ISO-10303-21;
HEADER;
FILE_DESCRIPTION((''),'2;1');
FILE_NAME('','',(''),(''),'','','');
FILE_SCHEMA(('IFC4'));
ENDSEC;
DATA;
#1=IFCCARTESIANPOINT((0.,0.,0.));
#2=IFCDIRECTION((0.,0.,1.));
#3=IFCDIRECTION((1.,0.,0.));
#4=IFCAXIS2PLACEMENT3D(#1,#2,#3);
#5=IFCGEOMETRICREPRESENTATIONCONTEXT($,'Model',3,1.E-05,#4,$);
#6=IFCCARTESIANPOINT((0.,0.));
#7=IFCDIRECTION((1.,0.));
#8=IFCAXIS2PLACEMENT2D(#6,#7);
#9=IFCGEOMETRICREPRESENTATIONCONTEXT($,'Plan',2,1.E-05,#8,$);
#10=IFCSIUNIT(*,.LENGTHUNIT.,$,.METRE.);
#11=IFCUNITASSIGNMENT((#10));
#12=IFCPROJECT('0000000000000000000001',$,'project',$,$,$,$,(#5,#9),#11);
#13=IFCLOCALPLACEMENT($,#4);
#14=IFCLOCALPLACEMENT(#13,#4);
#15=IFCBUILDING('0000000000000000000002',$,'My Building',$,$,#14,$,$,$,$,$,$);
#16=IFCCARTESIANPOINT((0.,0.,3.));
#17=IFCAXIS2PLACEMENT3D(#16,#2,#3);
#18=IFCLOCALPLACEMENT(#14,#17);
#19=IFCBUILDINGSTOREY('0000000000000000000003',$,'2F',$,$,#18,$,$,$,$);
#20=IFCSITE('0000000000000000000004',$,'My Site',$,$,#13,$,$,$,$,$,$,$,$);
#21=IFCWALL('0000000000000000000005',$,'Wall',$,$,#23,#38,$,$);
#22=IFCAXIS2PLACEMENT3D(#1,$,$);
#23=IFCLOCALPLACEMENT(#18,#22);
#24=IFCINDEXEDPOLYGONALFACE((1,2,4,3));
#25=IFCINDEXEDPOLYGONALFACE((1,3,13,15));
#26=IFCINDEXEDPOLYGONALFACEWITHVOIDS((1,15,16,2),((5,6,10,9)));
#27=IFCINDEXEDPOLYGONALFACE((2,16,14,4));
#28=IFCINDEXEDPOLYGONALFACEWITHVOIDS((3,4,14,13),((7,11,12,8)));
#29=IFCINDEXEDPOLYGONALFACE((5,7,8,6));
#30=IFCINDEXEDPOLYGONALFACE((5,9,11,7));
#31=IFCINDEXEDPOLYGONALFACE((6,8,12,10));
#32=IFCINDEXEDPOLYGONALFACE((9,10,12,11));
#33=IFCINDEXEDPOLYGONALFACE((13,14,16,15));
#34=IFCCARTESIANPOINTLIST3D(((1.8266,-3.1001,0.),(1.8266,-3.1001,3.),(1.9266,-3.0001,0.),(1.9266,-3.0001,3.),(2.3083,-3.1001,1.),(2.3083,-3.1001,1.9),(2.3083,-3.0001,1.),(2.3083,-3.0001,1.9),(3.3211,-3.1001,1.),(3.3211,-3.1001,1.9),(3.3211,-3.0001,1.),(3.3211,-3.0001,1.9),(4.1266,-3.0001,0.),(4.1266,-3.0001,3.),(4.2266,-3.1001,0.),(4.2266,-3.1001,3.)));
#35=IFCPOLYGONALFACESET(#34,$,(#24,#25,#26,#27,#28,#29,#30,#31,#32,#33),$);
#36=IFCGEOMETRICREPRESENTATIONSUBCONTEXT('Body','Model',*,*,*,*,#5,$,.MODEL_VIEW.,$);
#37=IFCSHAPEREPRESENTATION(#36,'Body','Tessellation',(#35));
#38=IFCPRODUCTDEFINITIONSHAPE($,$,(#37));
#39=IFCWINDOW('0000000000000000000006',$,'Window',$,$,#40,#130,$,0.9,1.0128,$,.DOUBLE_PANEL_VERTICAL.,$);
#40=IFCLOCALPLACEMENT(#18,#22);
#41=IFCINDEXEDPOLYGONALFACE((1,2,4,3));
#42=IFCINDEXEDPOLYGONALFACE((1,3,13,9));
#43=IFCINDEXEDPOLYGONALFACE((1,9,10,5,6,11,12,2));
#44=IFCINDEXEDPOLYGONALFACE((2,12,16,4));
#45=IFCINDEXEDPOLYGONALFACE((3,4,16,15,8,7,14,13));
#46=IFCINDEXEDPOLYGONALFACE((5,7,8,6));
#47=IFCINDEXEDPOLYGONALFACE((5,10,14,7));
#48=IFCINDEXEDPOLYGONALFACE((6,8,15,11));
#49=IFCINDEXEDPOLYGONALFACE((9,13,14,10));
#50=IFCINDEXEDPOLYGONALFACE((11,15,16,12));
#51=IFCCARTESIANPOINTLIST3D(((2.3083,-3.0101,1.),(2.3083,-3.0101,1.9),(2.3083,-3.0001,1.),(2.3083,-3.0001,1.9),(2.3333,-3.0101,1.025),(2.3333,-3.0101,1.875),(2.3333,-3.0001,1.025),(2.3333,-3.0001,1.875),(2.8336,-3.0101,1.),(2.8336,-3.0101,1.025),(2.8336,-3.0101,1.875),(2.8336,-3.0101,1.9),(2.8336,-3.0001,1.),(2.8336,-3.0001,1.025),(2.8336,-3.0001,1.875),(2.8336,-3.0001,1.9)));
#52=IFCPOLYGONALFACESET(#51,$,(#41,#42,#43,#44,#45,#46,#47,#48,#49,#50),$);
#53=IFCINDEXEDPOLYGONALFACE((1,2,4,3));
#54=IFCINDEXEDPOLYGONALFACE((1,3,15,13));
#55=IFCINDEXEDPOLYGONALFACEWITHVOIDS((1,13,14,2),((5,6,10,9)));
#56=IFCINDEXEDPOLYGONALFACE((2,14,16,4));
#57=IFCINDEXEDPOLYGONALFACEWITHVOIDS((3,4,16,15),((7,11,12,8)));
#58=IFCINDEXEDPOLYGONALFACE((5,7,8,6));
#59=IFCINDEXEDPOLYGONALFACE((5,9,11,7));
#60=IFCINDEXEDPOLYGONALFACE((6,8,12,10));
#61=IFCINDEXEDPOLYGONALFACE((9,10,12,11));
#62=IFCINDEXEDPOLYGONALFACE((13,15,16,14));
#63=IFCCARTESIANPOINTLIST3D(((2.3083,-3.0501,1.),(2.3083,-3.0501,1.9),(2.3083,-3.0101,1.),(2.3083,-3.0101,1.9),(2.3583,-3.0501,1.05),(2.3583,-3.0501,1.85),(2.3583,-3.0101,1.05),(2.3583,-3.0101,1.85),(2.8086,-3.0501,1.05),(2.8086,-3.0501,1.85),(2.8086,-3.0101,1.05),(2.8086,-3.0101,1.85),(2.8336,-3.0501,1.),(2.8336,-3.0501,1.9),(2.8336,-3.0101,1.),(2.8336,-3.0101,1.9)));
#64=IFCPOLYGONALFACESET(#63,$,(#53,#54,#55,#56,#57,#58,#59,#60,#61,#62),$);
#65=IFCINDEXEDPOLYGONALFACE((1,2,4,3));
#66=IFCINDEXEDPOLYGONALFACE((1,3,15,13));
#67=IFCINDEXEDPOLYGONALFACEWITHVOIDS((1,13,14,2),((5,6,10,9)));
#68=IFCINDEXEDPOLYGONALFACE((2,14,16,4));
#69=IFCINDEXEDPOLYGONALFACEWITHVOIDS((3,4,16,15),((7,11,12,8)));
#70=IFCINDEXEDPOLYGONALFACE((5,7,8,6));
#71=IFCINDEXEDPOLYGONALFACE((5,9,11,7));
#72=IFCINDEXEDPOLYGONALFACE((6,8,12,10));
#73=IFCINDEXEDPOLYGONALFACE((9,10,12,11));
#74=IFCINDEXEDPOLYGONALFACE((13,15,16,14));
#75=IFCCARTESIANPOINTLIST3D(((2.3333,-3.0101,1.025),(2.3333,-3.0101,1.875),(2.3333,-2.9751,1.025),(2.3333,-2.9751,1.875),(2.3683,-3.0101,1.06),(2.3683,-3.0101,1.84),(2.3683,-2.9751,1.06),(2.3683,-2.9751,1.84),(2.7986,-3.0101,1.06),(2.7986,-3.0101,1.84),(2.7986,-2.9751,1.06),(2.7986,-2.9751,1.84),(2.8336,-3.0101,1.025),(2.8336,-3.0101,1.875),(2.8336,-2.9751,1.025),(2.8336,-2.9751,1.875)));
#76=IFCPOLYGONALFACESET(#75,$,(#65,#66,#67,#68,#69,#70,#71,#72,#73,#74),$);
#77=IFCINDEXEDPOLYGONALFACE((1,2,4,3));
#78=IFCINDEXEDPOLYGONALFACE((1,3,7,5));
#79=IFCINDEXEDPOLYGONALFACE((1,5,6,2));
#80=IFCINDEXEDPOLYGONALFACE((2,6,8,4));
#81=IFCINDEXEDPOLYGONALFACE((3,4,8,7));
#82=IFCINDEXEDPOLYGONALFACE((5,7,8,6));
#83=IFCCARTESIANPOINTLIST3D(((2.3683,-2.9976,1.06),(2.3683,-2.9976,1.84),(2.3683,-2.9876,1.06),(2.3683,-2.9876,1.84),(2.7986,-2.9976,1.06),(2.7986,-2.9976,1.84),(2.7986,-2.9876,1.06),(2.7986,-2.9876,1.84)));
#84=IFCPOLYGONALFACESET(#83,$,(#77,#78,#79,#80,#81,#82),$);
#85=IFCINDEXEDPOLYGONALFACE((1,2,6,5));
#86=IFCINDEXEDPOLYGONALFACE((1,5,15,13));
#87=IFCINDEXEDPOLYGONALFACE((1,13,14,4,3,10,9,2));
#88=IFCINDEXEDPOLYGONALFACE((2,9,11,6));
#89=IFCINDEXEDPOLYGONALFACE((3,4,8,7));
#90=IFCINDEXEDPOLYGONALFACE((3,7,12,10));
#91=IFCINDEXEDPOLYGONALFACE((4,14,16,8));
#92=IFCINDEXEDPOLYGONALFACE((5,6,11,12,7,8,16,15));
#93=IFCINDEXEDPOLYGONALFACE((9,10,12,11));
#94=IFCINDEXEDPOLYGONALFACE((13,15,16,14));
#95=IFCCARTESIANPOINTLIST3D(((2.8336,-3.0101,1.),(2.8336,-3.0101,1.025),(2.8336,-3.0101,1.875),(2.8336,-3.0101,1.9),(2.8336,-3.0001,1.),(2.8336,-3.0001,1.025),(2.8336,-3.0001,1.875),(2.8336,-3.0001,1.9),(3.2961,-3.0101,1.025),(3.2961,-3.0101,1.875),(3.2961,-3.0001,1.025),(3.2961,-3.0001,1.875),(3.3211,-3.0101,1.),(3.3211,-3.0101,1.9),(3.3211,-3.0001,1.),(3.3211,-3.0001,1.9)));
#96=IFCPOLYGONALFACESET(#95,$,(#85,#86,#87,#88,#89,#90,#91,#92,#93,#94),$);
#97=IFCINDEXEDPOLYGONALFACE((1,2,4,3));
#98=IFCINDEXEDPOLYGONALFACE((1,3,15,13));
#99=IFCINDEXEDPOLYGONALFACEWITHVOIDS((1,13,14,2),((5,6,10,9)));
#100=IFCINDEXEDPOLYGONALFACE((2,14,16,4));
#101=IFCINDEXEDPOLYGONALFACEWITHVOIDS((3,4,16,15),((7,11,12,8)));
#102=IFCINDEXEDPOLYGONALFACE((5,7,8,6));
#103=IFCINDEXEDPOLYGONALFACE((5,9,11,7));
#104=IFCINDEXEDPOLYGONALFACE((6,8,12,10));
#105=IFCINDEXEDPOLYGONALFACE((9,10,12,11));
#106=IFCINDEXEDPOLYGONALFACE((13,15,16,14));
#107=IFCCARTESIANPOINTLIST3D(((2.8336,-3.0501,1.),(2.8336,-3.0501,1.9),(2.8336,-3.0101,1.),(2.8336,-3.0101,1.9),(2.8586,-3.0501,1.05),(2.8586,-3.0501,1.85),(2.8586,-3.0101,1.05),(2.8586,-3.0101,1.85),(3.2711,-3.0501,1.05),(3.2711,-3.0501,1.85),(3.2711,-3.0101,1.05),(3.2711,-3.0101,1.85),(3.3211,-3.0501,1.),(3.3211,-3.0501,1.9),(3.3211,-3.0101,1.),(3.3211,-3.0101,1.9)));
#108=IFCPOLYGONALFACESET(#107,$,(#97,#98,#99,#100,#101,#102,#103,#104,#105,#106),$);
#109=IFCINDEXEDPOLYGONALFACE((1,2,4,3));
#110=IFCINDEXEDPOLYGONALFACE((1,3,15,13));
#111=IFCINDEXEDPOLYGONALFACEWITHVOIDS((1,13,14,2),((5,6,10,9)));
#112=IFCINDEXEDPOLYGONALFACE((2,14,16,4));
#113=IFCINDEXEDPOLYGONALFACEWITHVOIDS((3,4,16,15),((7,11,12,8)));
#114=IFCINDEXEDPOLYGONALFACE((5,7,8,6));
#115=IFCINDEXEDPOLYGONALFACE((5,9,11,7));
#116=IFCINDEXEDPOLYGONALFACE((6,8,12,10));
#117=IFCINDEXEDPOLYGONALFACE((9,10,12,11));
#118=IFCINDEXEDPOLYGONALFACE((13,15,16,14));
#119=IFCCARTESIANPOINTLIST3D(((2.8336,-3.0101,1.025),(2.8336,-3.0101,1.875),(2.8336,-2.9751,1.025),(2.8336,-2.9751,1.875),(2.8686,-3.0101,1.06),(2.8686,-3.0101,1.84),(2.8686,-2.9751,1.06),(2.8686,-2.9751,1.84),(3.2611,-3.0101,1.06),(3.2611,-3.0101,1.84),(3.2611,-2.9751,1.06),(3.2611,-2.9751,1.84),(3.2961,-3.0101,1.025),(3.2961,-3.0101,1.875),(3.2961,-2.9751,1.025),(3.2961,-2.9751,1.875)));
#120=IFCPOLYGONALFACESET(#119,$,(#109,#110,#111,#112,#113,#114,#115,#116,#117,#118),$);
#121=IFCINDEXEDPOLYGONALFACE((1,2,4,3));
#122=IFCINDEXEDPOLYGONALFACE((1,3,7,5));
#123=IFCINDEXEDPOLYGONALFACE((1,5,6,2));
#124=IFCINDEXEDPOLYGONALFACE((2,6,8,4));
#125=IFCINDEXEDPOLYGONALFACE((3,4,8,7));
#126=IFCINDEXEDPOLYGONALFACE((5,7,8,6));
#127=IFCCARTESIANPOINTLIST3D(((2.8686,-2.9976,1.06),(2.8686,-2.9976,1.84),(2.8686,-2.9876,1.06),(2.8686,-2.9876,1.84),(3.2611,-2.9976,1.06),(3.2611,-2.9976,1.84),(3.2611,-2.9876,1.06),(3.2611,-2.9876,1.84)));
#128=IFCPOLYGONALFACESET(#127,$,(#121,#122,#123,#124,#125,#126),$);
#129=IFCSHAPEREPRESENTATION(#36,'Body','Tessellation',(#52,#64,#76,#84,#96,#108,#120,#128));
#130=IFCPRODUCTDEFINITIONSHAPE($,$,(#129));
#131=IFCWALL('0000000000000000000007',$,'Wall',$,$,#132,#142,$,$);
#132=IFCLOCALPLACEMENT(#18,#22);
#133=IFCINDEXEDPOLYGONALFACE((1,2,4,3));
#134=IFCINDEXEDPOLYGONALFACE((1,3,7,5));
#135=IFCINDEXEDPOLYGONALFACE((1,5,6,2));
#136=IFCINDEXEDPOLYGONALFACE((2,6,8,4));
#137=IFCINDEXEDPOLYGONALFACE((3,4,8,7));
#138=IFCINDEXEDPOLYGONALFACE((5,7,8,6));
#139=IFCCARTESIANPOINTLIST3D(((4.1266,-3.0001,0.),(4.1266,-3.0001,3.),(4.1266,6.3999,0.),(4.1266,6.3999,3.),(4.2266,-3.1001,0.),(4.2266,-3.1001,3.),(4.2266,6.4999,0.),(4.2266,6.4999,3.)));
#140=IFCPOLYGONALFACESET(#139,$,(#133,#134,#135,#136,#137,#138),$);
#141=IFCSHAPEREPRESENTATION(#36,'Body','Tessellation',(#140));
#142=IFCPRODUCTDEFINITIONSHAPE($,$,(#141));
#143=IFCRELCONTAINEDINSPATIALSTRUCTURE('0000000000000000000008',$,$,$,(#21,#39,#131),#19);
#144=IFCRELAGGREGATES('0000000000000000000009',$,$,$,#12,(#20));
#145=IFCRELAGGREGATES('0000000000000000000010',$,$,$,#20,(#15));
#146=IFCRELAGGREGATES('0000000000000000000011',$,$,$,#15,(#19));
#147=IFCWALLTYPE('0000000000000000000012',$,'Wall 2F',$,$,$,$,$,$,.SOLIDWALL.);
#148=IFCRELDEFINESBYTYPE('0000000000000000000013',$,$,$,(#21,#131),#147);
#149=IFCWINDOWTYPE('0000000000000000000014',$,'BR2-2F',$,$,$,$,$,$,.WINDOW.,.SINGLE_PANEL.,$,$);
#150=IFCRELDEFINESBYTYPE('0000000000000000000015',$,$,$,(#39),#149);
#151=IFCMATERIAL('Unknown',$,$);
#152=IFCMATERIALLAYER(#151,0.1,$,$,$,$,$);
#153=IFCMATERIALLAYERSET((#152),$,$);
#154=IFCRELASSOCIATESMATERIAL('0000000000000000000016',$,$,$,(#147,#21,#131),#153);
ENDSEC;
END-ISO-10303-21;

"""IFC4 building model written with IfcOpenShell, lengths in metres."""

from ifc_helpers import new_model, entity, si_unit, frame, origin_with_axes, origin_2d_with_axis, place, context, subcontext, project, spatial, line, indexed_curve, outline, extrude, shape, source, transform, mapped, material, layer, layer_set, layer_usage, type_object, type_shapes, element, fill, save


model = new_model("IFC4")

# Units and contexts
model_context = context("Model", 3, precision=1e-05, world=origin_with_axes())
plan_context = context("Plan", 2, precision=1e-05, world=origin_2d_with_axis())
body_context_1 = subcontext(model_context, "Body", "Model", "MODEL_VIEW")
body_context_2 = subcontext(plan_context, "Body", "Plan", "PLAN_VIEW")
ifc_project = project(units=[si_unit("LENGTHUNIT", "METRE")], contexts=[model_context, plan_context])

# Site, building, storey
site_placement = place(None, origin_with_axes())
site = spatial("IfcSite", under=ifc_project, at=site_placement, Name="My Site")
building_placement = place(site_placement, origin_with_axes())
building = spatial("IfcBuilding", under=site, at=building_placement, Name="My Building")
storey_placement = place(building_placement, frame((0.0, 0.0, 3.0), z_axis=(0.0, 0.0, 1.0), x_axis=(1.0, 0.0, 0.0)))
storey = spatial("IfcBuildingStorey", under=building, at=storey_placement, Name="2F")

# Shared definitions
ifc_material = material(Name="Unknown")

# Shared definitions
ifc_layer_1 = layer(ifc_material, 0.1)
ifc_layer_set_1 = layer_set([ifc_layer_1])
wall_type = type_object("IfcWallType", Name="Wall 2F", PredefinedType="SOLIDWALL", material=ifc_layer_set_1)

# Wall, opening, window
ifc_layer_usage_1 = layer_usage(ifc_layer_set_1, "AXIS2", "POSITIVE", 0.0)
wall_1_placement = place(storey_placement, frame((1.8266, -3.1001, 0.0), z_axis=(0.0, 0.0, 1.0), x_axis=(1.0, 0.0, 0.0)))
wall_1 = element("IfcWall", 1, at=wall_1_placement, inside=storey, type_object=wall_type, material=ifc_layer_usage_1, Name="Wall", context=body_context_1, shape_type="SweptSolid", body=[
    extrude(outline(indexed_curve([(0.0, 0.0), (0.1, 0.1), (2.3, 0.1), (2.4, 0.0)], segments=[line(1, 2, 3, 4, 1)])), origin_with_axes(), (0.0, 0.0, 1.0), 3.0),
])
shared_shape_1 = source(origin_with_axes(), body_context_1, "Body", "SweptSolid", [
    extrude(outline(indexed_curve([(0.0, 0.0), (1.0128, 0.0), (1.0128, 0.9), (0.0, 0.9)], segments=[line(1, 2, 3, 4, 1)])), frame((0.0, -0.6, 0.0), z_axis=(0.0, -1.0, 0.0), x_axis=(1.0, 0.0, 0.0)), (0.0, 0.0, -1.0), 1.2),
])
opening_1_placement = place(wall_1_placement, frame((0.4817, 0.0, 1.0), z_axis=(0.0, 0.0, 1.0), x_axis=(1.0, 0.0, 0.0)))
opening_1 = element("IfcOpeningElement", 2, at=opening_1_placement, cuts=wall_1, PredefinedType="OPENING", context=body_context_1, shape_type="MappedRepresentation", body=[
    mapped(shared_shape_1, transform((0.0, 0.0, 0.0), x_axis=(1.0, 0.0, 0.0), y_axis=(0.0, 1.0, 0.0), z_axis=(0.0, 0.0, 1.0), scale=1.0)),
])
window_type_1 = type_object("IfcWindowType", Name="BR2-2F", PartitioningType="SINGLE_PANEL", PredefinedType="WINDOW")
shared_shape_2 = source(origin_with_axes(), body_context_1, "Body", "SweptSolid", [
    extrude(outline(indexed_curve([(0.5254, 0.0), (0.0, 0.0), (0.0, 0.9), (0.5254, 0.9), (0.5254, 0.875), (0.025, 0.875), (0.025, 0.025), (0.5254, 0.025)], segments=[line(1, 2, 3, 4, 5, 6, 7, 8, 1)])), frame((0.0, 0.09, 0.0), z_axis=(0.0, -1.0, 0.0), x_axis=(1.0, 0.0, 0.0)), (0.0, 0.0, -1.0), 0.01),
    extrude(outline(indexed_curve([(0.0, 0.0), (0.5254, 0.0), (0.5254, 0.9), (0.0, 0.9)], segments=[line(1, 2, 3, 4, 1)]), holes=[indexed_curve([(0.05, 0.05), (0.5004, 0.05), (0.5004, 0.85), (0.05, 0.85)], segments=[line(1, 2, 3, 4, 1)])]), frame((0.0, 0.05, 0.0), z_axis=(0.0, -1.0, 0.0), x_axis=(1.0, 0.0, 0.0)), (0.0, 0.0, -1.0), 0.04),
    extrude(outline(indexed_curve([(0.0, 0.0), (0.5004, 0.0), (0.5004, 0.85), (0.0, 0.85)], segments=[line(1, 2, 3, 4, 1)]), holes=[indexed_curve([(0.035, 0.035), (0.4654, 0.035), (0.4654, 0.815), (0.035, 0.815)], segments=[line(1, 2, 3, 4, 1)])]), frame((0.025, 0.09, 0.025), z_axis=(0.0, -1.0, 0.0), x_axis=(1.0, 0.0, 0.0)), (0.0, 0.0, -1.0), 0.035),
    extrude(outline(indexed_curve([(0.035, 0.035), (0.4654, 0.035), (0.4654, 0.815), (0.035, 0.815)], segments=[line(1, 2, 3, 4, 1)])), frame((0.025, 0.1025, 0.025), z_axis=(0.0, -1.0, 0.0), x_axis=(1.0, 0.0, 0.0)), (0.0, 0.0, -1.0), 0.01),
    extrude(outline(indexed_curve([(0.0, 0.9), (0.4875, 0.9), (0.4875, 0.0), (0.0, 0.0), (0.0, 0.025), (0.4625, 0.025), (0.4625, 0.875), (0.0, 0.875)], segments=[line(1, 2, 3, 4, 5, 6, 7, 8, 1)])), frame((0.5254, 0.09, 0.0), z_axis=(0.0, -1.0, 0.0), x_axis=(1.0, 0.0, 0.0)), (0.0, 0.0, -1.0), 0.01),
    extrude(outline(indexed_curve([(0.0, 0.0), (0.4875, 0.0), (0.4875, 0.9), (0.0, 0.9)], segments=[line(1, 2, 3, 4, 1)]), holes=[indexed_curve([(0.025, 0.05), (0.4375, 0.05), (0.4375, 0.85), (0.025, 0.85)], segments=[line(1, 2, 3, 4, 1)])]), frame((0.5254, 0.05, 0.0), z_axis=(0.0, -1.0, 0.0), x_axis=(1.0, 0.0, 0.0)), (0.0, 0.0, -1.0), 0.04),
    extrude(outline(indexed_curve([(0.0, 0.0), (0.4625, 0.0), (0.4625, 0.85), (0.0, 0.85)], segments=[line(1, 2, 3, 4, 1)]), holes=[indexed_curve([(0.035, 0.035), (0.4275, 0.035), (0.4275, 0.815), (0.035, 0.815)], segments=[line(1, 2, 3, 4, 1)])]), frame((0.5254, 0.09, 0.025), z_axis=(0.0, -1.0, 0.0), x_axis=(1.0, 0.0, 0.0)), (0.0, 0.0, -1.0), 0.035),
    extrude(outline(indexed_curve([(0.035, 0.035), (0.4275, 0.035), (0.4275, 0.815), (0.035, 0.815)], segments=[line(1, 2, 3, 4, 1)])), frame((0.5254, 0.1025, 0.025), z_axis=(0.0, -1.0, 0.0), x_axis=(1.0, 0.0, 0.0)), (0.0, 0.0, -1.0), 0.01),
])
shared_shape_3 = source(origin_with_axes(), body_context_2, "Body", "Curve2D", [
    entity("IfcIndexedPolyCurve", entity("IfcCartesianPointList2D", [[0.05, 0.05], [0.5004, 0.05]])),
    entity("IfcIndexedPolyCurve", entity("IfcCartesianPointList2D", [[0.0, 0.1], [0.025, 0.1], [0.025, 0.09], [0.05, 0.09], [0.05, 0.05], [0.0, 0.05]]), [entity("IfcLineIndex", [1, 2, 3, 4, 5, 6, 1])]),
    entity("IfcIndexedPolyCurve", entity("IfcCartesianPointList2D", [[0.5254, 0.1], [0.5254, 0.1], [0.5254, 0.09], [0.5004, 0.09], [0.5004, 0.05], [0.5254, 0.05]])),
    entity("IfcIndexedPolyCurve", entity("IfcCartesianPointList2D", [[0.025, 0.09], [0.06, 0.09], [0.06, 0.125], [0.025, 0.125]]), [entity("IfcLineIndex", [1, 2, 3, 4, 1])]),
    entity("IfcIndexedPolyCurve", entity("IfcCartesianPointList2D", [[0.5254, 0.09], [0.4904, 0.09], [0.4904, 0.125], [0.5254, 0.125]]), [entity("IfcLineIndex", [1, 2, 3, 4, 1])]),
    entity("IfcIndexedPolyCurve", entity("IfcCartesianPointList2D", [[0.06, 0.09], [0.4904, 0.09]])),
    entity("IfcIndexedPolyCurve", entity("IfcCartesianPointList2D", [[0.06, 0.125], [0.4904, 0.125]])),
    entity("IfcIndexedPolyCurve", entity("IfcCartesianPointList2D", [[0.06, 0.1075], [0.4904, 0.1075]])),
    entity("IfcIndexedPolyCurve", entity("IfcCartesianPointList2D", [[0.5504, 0.05], [0.9628, 0.05]])),
    entity("IfcIndexedPolyCurve", entity("IfcCartesianPointList2D", [[0.5254, 0.1], [0.5254, 0.1], [0.5254, 0.09], [0.5504, 0.09], [0.5504, 0.05], [0.5254, 0.05]])),
    entity("IfcIndexedPolyCurve", entity("IfcCartesianPointList2D", [[1.0128, 0.1], [0.9878, 0.1], [0.9878, 0.09], [0.9628, 0.09], [0.9628, 0.05], [1.0128, 0.05]]), [entity("IfcLineIndex", [1, 2, 3, 4, 5, 6, 1])]),
    entity("IfcIndexedPolyCurve", entity("IfcCartesianPointList2D", [[0.5254, 0.09], [0.5604, 0.09], [0.5604, 0.125], [0.5254, 0.125]]), [entity("IfcLineIndex", [1, 2, 3, 4, 1])]),
    entity("IfcIndexedPolyCurve", entity("IfcCartesianPointList2D", [[0.9878, 0.09], [0.9528, 0.09], [0.9528, 0.125], [0.9878, 0.125]]), [entity("IfcLineIndex", [1, 2, 3, 4, 1])]),
    entity("IfcIndexedPolyCurve", entity("IfcCartesianPointList2D", [[0.5604, 0.09], [0.9528, 0.09]])),
    entity("IfcIndexedPolyCurve", entity("IfcCartesianPointList2D", [[0.5604, 0.125], [0.9528, 0.125]])),
    entity("IfcIndexedPolyCurve", entity("IfcCartesianPointList2D", [[0.5604, 0.1075], [0.9528, 0.1075]])),
])
type_shapes(window_type_1, [shared_shape_2, shared_shape_3])
window_1_placement = place(opening_1_placement, frame((0.0, 0.0, 0.0), z_axis=(0.0, 0.0, 1.0), x_axis=(1.0, 0.0, 0.0)))
window_1 = element("IfcWindow", 3, at=window_1_placement, inside=storey, type_object=window_type_1, Name="Window", OverallHeight=0.9, OverallWidth=1.0128, PartitioningType="DOUBLE_PANEL_VERTICAL", shapes=[
    shape(body_context_1, "Body", "MappedRepresentation", [mapped(shared_shape_2, transform((0.0, 0.0, 0.0), x_axis=(1.0, 0.0, 0.0), y_axis=(0.0, 1.0, 0.0), z_axis=(0.0, 0.0, 1.0), scale=1.0))]),
    shape(body_context_2, "Body", "MappedRepresentation", [mapped(shared_shape_3, transform((0.0, 0.0, 0.0), x_axis=(1.0, 0.0, 0.0), y_axis=(0.0, 1.0, 0.0), z_axis=(0.0, 0.0, 1.0), scale=1.0))]),
])
fill(opening_1, window_1)

# Wall
ifc_layer_usage_2 = layer_usage(ifc_layer_set_1, "AXIS2", "POSITIVE", 0.0)
wall_2_placement = place(storey_placement, frame((4.2266, -3.1001, 0.0), z_axis=(0.0, 0.0, 1.0), x_axis=(0.0, 1.0, 0.0)))
element("IfcWall", 4, at=wall_2_placement, inside=storey, type_object=wall_type, material=ifc_layer_usage_2, Name="Wall", context=body_context_1, shape_type="SweptSolid", body=[
    extrude(outline(indexed_curve([(0.0, 0.0), (0.1, 0.1), (9.5, 0.1), (9.6, 0.0)], segments=[line(1, 2, 3, 4, 1)])), origin_with_axes(), (0.0, 0.0, 1.0), 3.0),
])

save(model, "model.ifc")
